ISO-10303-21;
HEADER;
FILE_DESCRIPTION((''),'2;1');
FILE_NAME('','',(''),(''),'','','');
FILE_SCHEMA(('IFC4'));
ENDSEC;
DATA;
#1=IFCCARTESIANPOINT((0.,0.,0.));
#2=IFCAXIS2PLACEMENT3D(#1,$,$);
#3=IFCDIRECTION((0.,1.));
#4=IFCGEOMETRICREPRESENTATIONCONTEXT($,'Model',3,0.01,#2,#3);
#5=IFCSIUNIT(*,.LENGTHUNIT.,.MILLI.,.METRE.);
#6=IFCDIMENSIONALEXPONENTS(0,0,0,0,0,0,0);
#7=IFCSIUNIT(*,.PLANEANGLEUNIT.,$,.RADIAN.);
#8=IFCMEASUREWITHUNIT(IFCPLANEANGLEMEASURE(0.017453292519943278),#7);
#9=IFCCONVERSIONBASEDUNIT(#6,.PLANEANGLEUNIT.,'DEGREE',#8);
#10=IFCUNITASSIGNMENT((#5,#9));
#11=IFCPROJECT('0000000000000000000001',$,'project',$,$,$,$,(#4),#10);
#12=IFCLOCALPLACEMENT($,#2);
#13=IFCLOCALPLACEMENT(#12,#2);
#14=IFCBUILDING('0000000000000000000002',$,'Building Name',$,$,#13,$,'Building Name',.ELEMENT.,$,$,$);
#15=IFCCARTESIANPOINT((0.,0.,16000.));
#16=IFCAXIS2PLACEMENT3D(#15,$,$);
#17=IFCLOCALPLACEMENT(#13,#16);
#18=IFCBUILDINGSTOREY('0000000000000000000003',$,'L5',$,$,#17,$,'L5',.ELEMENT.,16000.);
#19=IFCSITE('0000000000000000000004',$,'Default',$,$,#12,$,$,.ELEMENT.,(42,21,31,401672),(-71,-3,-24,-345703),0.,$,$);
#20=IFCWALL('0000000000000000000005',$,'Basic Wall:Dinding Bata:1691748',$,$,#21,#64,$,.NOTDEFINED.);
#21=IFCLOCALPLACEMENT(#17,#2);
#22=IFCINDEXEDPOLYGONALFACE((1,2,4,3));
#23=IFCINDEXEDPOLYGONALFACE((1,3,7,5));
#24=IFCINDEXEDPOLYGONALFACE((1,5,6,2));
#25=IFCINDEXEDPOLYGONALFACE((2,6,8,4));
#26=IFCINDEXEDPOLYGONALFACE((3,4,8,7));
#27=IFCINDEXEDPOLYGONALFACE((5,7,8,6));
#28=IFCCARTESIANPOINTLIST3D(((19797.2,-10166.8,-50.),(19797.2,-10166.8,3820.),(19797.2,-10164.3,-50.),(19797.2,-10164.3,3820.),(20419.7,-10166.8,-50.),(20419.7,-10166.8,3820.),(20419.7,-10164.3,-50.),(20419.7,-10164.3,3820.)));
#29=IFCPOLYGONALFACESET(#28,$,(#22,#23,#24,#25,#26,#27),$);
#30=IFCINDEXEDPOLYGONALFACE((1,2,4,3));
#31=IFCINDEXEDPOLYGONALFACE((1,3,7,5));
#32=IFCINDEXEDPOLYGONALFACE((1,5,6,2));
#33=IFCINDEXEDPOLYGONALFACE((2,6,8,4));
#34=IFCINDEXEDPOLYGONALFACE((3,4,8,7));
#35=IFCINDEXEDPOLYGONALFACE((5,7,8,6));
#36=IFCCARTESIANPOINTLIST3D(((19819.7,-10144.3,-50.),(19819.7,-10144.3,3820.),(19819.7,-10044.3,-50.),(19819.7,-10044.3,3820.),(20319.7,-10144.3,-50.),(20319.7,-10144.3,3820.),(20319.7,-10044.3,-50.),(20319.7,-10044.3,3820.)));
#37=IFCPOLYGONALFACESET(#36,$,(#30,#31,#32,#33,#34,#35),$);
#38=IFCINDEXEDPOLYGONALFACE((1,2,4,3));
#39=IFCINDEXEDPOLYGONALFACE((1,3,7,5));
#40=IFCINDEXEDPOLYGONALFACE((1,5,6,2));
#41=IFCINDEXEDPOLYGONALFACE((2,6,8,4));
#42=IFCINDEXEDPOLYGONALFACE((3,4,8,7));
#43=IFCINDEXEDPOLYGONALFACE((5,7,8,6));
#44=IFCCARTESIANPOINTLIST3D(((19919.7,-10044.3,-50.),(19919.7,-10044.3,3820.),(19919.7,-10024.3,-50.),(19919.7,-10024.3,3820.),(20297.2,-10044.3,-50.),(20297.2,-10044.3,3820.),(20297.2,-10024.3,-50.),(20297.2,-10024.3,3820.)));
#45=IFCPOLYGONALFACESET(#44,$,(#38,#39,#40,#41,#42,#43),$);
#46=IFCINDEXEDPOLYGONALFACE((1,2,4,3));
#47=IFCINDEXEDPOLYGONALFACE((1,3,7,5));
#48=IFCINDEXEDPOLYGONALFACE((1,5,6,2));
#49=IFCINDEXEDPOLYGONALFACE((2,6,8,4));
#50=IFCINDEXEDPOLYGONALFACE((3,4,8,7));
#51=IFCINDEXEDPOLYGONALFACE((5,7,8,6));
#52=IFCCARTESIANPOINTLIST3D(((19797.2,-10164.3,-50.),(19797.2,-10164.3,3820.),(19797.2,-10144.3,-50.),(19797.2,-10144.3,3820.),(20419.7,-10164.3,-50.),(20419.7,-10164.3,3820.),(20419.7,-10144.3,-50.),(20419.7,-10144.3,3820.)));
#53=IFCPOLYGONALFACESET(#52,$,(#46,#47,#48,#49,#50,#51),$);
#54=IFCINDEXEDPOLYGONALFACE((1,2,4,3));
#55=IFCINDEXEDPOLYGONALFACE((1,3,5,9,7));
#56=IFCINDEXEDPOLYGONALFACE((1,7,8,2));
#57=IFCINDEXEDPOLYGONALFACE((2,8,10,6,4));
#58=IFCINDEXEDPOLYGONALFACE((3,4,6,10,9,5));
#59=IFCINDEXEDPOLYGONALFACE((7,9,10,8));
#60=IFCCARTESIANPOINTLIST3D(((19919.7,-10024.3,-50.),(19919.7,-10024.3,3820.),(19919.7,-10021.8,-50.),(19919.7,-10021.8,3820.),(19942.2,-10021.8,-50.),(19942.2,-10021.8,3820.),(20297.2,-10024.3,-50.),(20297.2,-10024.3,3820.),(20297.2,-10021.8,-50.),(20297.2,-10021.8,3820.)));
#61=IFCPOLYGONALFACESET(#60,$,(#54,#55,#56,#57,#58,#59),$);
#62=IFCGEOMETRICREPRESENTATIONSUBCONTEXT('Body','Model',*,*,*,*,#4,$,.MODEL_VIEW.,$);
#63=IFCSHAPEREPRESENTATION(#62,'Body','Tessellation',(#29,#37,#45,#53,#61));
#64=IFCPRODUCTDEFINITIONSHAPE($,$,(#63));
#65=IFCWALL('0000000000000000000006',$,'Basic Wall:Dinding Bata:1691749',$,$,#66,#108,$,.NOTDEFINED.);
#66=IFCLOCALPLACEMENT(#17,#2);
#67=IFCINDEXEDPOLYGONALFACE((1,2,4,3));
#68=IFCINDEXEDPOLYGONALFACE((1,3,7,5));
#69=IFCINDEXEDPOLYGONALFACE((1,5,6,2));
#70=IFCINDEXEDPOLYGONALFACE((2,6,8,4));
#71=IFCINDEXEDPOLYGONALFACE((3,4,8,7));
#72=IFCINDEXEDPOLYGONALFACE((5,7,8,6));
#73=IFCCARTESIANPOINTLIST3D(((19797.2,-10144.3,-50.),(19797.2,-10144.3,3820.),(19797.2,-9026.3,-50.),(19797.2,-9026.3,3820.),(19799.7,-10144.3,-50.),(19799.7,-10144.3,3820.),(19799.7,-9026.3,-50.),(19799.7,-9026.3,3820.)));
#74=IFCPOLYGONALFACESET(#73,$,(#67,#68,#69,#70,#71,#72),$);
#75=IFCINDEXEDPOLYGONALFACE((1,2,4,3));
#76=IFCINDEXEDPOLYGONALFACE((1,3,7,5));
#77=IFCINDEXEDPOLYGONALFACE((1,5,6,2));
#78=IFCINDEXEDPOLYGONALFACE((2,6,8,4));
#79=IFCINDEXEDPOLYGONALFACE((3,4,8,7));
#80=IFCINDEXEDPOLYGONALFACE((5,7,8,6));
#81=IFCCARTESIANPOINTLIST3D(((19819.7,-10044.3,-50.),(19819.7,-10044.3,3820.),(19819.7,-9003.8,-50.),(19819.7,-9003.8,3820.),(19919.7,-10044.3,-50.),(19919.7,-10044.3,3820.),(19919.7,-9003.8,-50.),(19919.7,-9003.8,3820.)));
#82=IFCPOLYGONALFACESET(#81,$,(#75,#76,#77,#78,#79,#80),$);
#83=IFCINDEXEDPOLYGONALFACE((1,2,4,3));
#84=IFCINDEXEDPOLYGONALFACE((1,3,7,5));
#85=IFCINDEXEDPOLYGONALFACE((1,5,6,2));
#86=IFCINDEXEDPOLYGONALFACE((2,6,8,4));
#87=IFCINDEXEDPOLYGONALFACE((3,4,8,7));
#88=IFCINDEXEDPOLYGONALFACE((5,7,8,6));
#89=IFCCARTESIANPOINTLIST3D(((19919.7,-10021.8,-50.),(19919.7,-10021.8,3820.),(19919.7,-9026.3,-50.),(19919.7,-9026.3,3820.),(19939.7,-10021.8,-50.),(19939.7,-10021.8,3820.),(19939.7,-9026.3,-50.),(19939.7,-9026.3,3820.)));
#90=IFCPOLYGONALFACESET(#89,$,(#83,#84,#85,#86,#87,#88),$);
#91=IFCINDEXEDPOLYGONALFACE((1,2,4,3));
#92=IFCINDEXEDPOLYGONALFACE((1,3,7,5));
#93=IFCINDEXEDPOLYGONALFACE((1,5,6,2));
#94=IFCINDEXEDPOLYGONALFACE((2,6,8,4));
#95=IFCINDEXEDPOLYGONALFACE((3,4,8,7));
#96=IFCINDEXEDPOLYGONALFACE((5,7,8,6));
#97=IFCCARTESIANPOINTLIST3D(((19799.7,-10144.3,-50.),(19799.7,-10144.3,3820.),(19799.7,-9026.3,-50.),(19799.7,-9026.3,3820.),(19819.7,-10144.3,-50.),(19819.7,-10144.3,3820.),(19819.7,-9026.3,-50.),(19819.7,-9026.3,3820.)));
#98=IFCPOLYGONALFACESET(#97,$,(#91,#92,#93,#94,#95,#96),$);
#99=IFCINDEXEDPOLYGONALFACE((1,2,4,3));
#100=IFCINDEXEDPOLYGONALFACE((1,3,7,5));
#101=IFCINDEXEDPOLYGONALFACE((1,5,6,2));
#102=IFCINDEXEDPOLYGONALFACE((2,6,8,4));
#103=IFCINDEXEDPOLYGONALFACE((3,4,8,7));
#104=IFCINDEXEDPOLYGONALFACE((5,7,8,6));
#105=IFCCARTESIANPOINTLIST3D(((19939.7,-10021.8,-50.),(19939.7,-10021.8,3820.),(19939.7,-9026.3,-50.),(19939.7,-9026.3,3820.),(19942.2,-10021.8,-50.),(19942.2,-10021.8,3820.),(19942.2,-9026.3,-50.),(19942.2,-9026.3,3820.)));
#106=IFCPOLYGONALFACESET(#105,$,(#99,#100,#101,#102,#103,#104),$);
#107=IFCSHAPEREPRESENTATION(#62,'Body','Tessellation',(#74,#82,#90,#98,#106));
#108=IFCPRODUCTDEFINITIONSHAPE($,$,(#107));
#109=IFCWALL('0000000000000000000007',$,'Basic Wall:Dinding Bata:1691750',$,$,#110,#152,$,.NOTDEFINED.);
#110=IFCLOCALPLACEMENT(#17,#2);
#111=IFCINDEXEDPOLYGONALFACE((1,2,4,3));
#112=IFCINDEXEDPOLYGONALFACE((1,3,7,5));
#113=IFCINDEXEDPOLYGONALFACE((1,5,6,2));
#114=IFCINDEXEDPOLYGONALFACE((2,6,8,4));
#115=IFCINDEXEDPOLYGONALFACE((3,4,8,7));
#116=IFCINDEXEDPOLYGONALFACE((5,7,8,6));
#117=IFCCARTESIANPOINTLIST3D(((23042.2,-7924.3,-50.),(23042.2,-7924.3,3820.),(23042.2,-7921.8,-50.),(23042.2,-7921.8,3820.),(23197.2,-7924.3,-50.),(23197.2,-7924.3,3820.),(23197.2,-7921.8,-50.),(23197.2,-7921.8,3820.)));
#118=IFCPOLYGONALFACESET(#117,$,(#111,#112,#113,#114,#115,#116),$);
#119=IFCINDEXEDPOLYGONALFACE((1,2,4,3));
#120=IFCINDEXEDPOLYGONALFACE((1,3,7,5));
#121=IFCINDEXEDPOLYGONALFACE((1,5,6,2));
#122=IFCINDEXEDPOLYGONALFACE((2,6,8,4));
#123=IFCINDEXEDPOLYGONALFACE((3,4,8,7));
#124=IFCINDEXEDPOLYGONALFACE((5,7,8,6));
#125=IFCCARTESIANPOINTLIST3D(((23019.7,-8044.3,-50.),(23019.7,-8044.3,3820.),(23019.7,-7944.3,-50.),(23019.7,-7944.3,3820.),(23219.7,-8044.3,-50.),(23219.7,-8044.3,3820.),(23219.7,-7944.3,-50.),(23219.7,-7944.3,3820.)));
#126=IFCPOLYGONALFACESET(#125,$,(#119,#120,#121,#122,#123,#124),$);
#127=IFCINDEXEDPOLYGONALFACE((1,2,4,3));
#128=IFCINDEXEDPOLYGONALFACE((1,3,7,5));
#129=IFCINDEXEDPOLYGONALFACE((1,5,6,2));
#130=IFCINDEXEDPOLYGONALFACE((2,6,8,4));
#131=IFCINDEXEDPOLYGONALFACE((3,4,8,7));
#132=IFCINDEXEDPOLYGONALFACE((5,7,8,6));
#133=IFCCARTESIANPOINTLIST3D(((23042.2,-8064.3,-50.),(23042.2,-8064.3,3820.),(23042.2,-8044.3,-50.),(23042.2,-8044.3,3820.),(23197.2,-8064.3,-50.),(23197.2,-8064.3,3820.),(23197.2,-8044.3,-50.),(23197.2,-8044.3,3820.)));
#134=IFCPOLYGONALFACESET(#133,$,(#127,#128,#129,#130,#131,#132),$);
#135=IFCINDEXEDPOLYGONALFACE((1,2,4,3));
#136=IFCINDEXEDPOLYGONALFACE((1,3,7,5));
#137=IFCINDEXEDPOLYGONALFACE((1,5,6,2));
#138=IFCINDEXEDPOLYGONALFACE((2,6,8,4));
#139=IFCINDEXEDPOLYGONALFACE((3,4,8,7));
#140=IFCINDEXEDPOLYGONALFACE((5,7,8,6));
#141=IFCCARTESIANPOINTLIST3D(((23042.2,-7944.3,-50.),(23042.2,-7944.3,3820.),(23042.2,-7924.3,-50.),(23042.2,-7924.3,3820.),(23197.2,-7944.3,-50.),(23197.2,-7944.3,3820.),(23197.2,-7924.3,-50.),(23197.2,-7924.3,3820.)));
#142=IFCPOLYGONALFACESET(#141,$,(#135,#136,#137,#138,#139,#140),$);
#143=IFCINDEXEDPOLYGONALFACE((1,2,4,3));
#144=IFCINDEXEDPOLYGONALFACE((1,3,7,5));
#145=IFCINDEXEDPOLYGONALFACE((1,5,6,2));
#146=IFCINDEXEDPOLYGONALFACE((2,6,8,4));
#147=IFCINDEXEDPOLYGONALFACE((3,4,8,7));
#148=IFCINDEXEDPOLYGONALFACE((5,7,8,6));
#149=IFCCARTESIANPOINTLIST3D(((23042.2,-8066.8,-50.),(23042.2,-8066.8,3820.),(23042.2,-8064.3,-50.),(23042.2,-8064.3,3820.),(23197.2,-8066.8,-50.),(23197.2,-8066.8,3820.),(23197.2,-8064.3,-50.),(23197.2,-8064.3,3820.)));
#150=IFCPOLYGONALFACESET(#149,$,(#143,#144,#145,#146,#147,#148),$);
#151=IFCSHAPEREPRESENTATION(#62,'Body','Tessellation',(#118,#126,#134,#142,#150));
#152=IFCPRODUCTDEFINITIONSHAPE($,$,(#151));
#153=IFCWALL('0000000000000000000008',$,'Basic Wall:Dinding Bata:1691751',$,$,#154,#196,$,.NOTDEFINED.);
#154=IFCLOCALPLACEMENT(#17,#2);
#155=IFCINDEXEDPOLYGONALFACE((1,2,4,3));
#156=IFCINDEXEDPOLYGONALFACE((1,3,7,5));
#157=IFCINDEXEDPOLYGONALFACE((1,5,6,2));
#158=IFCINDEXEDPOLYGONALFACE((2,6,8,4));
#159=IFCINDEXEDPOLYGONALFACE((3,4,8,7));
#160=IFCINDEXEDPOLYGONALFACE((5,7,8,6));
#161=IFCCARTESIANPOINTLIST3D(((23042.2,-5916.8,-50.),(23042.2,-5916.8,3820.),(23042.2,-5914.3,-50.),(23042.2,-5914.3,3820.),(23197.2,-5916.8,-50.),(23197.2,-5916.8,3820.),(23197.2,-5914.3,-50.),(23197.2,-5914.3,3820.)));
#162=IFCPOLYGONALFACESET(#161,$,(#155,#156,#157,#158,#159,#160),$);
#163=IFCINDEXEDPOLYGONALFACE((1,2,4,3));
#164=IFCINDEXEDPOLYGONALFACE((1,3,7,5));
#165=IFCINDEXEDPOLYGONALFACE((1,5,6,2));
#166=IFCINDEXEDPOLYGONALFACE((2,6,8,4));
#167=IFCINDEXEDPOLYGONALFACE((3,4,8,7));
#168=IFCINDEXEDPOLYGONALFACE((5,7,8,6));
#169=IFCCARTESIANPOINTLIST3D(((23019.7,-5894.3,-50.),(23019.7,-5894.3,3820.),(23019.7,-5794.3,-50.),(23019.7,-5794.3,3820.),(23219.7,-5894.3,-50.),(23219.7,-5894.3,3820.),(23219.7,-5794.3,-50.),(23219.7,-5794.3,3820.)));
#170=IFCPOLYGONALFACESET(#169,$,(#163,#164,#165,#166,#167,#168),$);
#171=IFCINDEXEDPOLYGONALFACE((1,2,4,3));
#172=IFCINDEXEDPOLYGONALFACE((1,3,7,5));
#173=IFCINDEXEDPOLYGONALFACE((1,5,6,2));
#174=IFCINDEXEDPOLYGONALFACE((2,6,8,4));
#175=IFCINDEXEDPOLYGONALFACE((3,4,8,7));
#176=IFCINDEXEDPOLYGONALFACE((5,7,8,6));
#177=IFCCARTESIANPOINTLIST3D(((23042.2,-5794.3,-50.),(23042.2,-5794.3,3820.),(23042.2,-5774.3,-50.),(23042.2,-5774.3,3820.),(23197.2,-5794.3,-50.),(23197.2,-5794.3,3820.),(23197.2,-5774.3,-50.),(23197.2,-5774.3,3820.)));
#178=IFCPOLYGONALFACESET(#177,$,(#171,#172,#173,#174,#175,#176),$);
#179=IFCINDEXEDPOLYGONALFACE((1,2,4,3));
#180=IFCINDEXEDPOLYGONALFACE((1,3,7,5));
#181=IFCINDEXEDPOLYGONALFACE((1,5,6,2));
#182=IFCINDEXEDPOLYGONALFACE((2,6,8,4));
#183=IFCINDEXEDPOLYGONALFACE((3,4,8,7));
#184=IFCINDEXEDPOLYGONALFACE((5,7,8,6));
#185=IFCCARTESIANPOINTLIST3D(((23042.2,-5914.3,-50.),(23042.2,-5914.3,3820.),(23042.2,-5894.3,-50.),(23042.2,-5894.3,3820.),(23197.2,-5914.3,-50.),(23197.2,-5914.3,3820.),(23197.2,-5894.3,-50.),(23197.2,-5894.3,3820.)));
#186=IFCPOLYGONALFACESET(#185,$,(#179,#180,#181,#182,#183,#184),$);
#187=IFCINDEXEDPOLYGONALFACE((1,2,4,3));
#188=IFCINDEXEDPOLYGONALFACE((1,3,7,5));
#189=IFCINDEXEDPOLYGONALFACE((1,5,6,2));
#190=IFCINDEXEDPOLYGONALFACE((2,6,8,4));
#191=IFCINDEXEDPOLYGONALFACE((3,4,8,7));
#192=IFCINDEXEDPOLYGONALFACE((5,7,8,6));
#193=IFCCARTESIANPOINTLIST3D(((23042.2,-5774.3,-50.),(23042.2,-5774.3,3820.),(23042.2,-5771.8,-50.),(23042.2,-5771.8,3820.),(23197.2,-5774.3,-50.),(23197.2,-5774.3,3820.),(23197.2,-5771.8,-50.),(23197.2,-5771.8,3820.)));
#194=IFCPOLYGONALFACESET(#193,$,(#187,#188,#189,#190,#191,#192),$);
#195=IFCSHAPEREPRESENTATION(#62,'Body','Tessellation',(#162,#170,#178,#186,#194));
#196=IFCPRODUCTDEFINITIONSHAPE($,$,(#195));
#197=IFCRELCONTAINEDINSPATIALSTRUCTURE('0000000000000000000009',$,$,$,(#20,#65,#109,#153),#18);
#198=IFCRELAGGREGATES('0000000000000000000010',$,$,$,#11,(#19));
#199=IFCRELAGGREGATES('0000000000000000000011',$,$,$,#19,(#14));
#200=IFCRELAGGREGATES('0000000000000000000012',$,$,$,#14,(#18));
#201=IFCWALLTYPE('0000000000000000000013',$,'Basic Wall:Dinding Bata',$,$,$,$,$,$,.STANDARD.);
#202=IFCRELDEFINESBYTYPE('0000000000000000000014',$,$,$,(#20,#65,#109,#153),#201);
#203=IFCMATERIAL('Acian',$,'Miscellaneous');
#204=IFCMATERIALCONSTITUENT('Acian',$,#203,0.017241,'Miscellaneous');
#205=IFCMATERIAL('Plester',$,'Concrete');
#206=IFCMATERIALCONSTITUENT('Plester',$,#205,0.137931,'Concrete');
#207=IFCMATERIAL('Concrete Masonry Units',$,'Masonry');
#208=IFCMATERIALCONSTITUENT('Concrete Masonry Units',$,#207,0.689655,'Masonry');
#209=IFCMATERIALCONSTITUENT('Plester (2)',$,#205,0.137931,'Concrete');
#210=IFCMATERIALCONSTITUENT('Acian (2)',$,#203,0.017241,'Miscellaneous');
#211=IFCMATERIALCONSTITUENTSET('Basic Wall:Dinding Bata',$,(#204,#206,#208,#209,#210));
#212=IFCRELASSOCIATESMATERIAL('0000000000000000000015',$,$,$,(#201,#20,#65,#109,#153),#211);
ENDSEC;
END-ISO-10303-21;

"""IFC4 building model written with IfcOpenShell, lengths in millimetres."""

from ifc_helpers import new_model, entity, si_unit, converted_unit, direction, frame, origin, place, context, subcontext, project, spatial, indexed_curve, outline, extrude, material, constituent, constituent_set, type_object, element, save


model = new_model("IFC4")

# Units and contexts
model_context = context("Model", 3, precision=0.01, world=origin(), true_north=direction((0.0, 1.0)))
body_context = subcontext(model_context, "Body", "Model", "MODEL_VIEW")
ifc_project = project(units=[si_unit("LENGTHUNIT", "METRE", prefix="MILLI"), converted_unit("PLANEANGLEUNIT", "DEGREE", entity("IfcPlaneAngleMeasure", 0.017453292519943278), si_unit("PLANEANGLEUNIT", "RADIAN"), dimensions=[0, 0, 0, 0, 0, 0, 0])], contexts=[model_context])

# Site, building, storey
site_placement = place(None, origin())
site = spatial("IfcSite", under=ifc_project, at=site_placement, Name="Default", CompositionType="ELEMENT", RefLatitude=(42, 21, 31, 401672), RefLongitude=(-71, -3, -24, -345703), RefElevation=0.0)
building_placement = place(site_placement, origin())
building = spatial("IfcBuilding", under=site, at=building_placement, Name="Building Name", LongName="Building Name", CompositionType="ELEMENT")
storey_placement = place(building_placement, frame((0.0, 0.0, 16000.0)))
storey = spatial("IfcBuildingStorey", under=building, at=storey_placement, Name="L5", LongName="L5", CompositionType="ELEMENT", Elevation=16000.0)

# Walls
ifc_material_1 = material(Name="Acian", Category="Miscellaneous")
ifc_constituent_1 = constituent(ifc_material_1, Name="Acian", Category="Miscellaneous", fraction=0.017241)
ifc_material_2 = material(Name="Plester", Category="Concrete")
ifc_constituent_2 = constituent(ifc_material_2, Name="Plester", Category="Concrete", fraction=0.137931)
ifc_material_3 = material(Name="Concrete Masonry Units", Category="Masonry")
ifc_constituent_3 = constituent(ifc_material_3, Name="Concrete Masonry Units", Category="Masonry", fraction=0.689655)
ifc_constituent_4 = constituent(ifc_material_2, Name="Plester (2)", Category="Concrete", fraction=0.137931)
ifc_constituent_5 = constituent(ifc_material_1, Name="Acian (2)", Category="Miscellaneous", fraction=0.017241)
ifc_constituent_set = constituent_set(constituents=[ifc_constituent_1, ifc_constituent_2, ifc_constituent_3, ifc_constituent_4, ifc_constituent_5], Name="Basic Wall:Dinding Bata")
wall_type = type_object("IfcWallType", Name="Basic Wall:Dinding Bata", PredefinedType="STANDARD", material=ifc_constituent_set)
wall_1_placement = place(storey_placement, frame((20297.2, -10094.3, -50.0), z_axis=(0.0, 0.0, 1.0), x_axis=(-1.0, 0.0, 0.0)))
element("IfcWall", 1, at=wall_1_placement, inside=storey, type_object=wall_type, material=ifc_constituent_set, Name="Basic Wall:Dinding Bata:1691748", PredefinedType="NOTDEFINED", context=body_context, shape_type="SweptSolid", body=[
    extrude(outline(indexed_curve([(-1.3, -311.3), (1.2, -311.3), (1.3, 311.3), (-1.2, 311.3), (-1.3, -311.3)], self_intersect=False)), frame((188.8, 71.3, 0.0), z_axis=(0.0, 0.0, 1.0), x_axis=(0.0, -1.0, 0.0)), (0.0, 0.0, 1.0), 3870.0),
    extrude(outline(indexed_curve([(-250.0, -50.0), (250.0, -50.0), (250.0, 50.0), (-250.0, 50.0), (-250.0, -50.0)], self_intersect=False)), frame((227.5, 0.0, 0.0)), (0.0, 0.0, 1.0), 3870.0),
    extrude(outline(indexed_curve([(-188.8, -10.0), (188.8, -10.0), (188.8, 10.0), (-188.8, 10.0), (-188.8, -10.0)], self_intersect=False)), frame((188.8, -60.0, 0.0)), (0.0, 0.0, 1.0), 3870.0),
    extrude(outline(indexed_curve([(-311.3, -10.0), (311.3, -10.0), (311.3, 10.0), (-311.3, 10.0), (-311.3, -10.0)], self_intersect=False)), frame((188.8, 60.0, 0.0)), (0.0, 0.0, 1.0), 3870.0),
    extrude(outline(indexed_curve([(133.0, -1.0), (155.5, -1.0), (155.5, 1.5), (-222.0, 1.5), (-222.0, -1.0), (133.0, -1.0)], self_intersect=False)), frame((222.0, -71.5, 0.0)), (0.0, 0.0, 1.0), 3870.0),
])
wall_2_placement = place(storey_placement, frame((19869.7, -10021.8, -50.0), z_axis=(0.0, 0.0, 1.0), x_axis=(0.0, 1.0, 0.0)))
element("IfcWall", 2, at=wall_2_placement, inside=storey, type_object=wall_type, material=ifc_constituent_set, Name="Basic Wall:Dinding Bata:1691749", PredefinedType="NOTDEFINED", context=body_context, shape_type="SweptSolid", body=[
    extrude(outline(indexed_curve([(-1.2, -559.0), (1.2, -559.0), (1.2, 559.0), (-1.2, 559.0), (-1.2, -559.0)], self_intersect=False)), frame((436.5, 71.3, 0.0), z_axis=(0.0, 0.0, 1.0), x_axis=(0.0, -1.0, 0.0)), (0.0, 0.0, 1.0), 3870.0),
    extrude(outline(indexed_curve([(-520.2, -50.0), (520.2, -50.0), (520.2, 50.0), (-520.2, 50.0), (-520.2, -50.0)], self_intersect=False)), frame((497.7, 0.0, 0.0)), (0.0, 0.0, 1.0), 3870.0),
    extrude(outline(indexed_curve([(-497.7, -10.0), (497.7, -10.0), (497.7, 10.0), (-497.7, 10.0), (-497.7, -10.0)], self_intersect=False)), frame((497.7, -60.0, 0.0)), (0.0, 0.0, 1.0), 3870.0),
    extrude(outline(indexed_curve([(-559.0, -10.0), (559.0, -10.0), (559.0, 10.0), (-559.0, 10.0), (-559.0, -10.0)], self_intersect=False)), frame((436.5, 60.0, 0.0)), (0.0, 0.0, 1.0), 3870.0),
    extrude(outline(indexed_curve([(-1.2, -497.7), (1.2, -497.7), (1.2, 497.7), (-1.2, 497.7), (-1.2, -497.7)], self_intersect=False)), frame((497.7, -71.3, 0.0), z_axis=(0.0, 0.0, 1.0), x_axis=(0.0, 1.0, 0.0)), (0.0, 0.0, 1.0), 3870.0),
])
wall_3_placement = place(storey_placement, frame((23042.2, -7994.3, -50.0)))
element("IfcWall", 3, at=wall_3_placement, inside=storey, type_object=wall_type, material=ifc_constituent_set, Name="Basic Wall:Dinding Bata:1691750", PredefinedType="NOTDEFINED", context=body_context, shape_type="SweptSolid", body=[
    extrude(outline(indexed_curve([(-1.2, -77.5), (1.2, -77.5), (1.2, 77.5), (-1.2, 77.5), (-1.2, -77.5)], self_intersect=False)), frame((77.5, 71.3, 0.0), z_axis=(0.0, 0.0, 1.0), x_axis=(0.0, -1.0, 0.0)), (0.0, 0.0, 1.0), 3870.0),
    extrude(outline(indexed_curve([(-100.0, -50.0), (100.0, -50.0), (100.0, 50.0), (-100.0, 50.0), (-100.0, -50.0)], self_intersect=False)), frame((77.5, 0.0, 0.0)), (0.0, 0.0, 1.0), 3870.0),
    extrude(outline(indexed_curve([(-77.5, -10.0), (77.5, -10.0), (77.5, 10.0), (-77.5, 10.0), (-77.5, -10.0)], self_intersect=False)), frame((77.5, -60.0, 0.0)), (0.0, 0.0, 1.0), 3870.0),
    extrude(outline(indexed_curve([(-77.5, -10.0), (77.5, -10.0), (77.5, 10.0), (-77.5, 10.0), (-77.5, -10.0)], self_intersect=False)), frame((77.5, 60.0, 0.0)), (0.0, 0.0, 1.0), 3870.0),
    extrude(outline(indexed_curve([(-1.2, -77.5), (1.2, -77.5), (1.2, 77.5), (-1.2, 77.5), (-1.2, -77.5)], self_intersect=False)), frame((77.5, -71.3, 0.0), z_axis=(0.0, 0.0, 1.0), x_axis=(0.0, 1.0, 0.0)), (0.0, 0.0, 1.0), 3870.0),
])
wall_4_placement = place(storey_placement, frame((23197.2, -5844.3, -50.0), z_axis=(0.0, 0.0, 1.0), x_axis=(-1.0, 0.0, 0.0)))
element("IfcWall", 4, at=wall_4_placement, inside=storey, type_object=wall_type, material=ifc_constituent_set, Name="Basic Wall:Dinding Bata:1691751", PredefinedType="NOTDEFINED", context=body_context, shape_type="SweptSolid", body=[
    extrude(outline(indexed_curve([(-1.3, -77.5), (1.2, -77.5), (1.2, 77.5), (-1.2, 77.5), (-1.3, -77.5)], self_intersect=False)), frame((77.5, 71.2, 0.0), z_axis=(0.0, 0.0, 1.0), x_axis=(0.0, -1.0, 0.0)), (0.0, 0.0, 1.0), 3870.0),
    extrude(outline(indexed_curve([(-100.0, -50.0), (100.0, -50.0), (100.0, 50.0), (-100.0, 50.0), (-100.0, -50.0)], self_intersect=False)), frame((77.5, 0.0, 0.0)), (0.0, 0.0, 1.0), 3870.0),
    extrude(outline(indexed_curve([(-77.5, -10.0), (77.5, -10.0), (77.5, 10.0), (-77.5, 10.0), (-77.5, -10.0)], self_intersect=False)), frame((77.5, -60.0, 0.0)), (0.0, 0.0, 1.0), 3870.0),
    extrude(outline(indexed_curve([(-77.5, -10.0), (77.5, -10.0), (77.5, 10.0), (-77.5, 10.0), (-77.5, -10.0)], self_intersect=False)), frame((77.5, 60.0, 0.0)), (0.0, 0.0, 1.0), 3870.0),
    extrude(outline(indexed_curve([(-1.2, -77.5), (1.2, -77.5), (1.3, 77.5), (-1.2, 77.5), (-1.2, -77.5)], self_intersect=False)), frame((77.5, -71.3, 0.0), z_axis=(0.0, 0.0, 1.0), x_axis=(0.0, 1.0, 0.0)), (0.0, 0.0, 1.0), 3870.0),
])

save(model, "model.ifc")
